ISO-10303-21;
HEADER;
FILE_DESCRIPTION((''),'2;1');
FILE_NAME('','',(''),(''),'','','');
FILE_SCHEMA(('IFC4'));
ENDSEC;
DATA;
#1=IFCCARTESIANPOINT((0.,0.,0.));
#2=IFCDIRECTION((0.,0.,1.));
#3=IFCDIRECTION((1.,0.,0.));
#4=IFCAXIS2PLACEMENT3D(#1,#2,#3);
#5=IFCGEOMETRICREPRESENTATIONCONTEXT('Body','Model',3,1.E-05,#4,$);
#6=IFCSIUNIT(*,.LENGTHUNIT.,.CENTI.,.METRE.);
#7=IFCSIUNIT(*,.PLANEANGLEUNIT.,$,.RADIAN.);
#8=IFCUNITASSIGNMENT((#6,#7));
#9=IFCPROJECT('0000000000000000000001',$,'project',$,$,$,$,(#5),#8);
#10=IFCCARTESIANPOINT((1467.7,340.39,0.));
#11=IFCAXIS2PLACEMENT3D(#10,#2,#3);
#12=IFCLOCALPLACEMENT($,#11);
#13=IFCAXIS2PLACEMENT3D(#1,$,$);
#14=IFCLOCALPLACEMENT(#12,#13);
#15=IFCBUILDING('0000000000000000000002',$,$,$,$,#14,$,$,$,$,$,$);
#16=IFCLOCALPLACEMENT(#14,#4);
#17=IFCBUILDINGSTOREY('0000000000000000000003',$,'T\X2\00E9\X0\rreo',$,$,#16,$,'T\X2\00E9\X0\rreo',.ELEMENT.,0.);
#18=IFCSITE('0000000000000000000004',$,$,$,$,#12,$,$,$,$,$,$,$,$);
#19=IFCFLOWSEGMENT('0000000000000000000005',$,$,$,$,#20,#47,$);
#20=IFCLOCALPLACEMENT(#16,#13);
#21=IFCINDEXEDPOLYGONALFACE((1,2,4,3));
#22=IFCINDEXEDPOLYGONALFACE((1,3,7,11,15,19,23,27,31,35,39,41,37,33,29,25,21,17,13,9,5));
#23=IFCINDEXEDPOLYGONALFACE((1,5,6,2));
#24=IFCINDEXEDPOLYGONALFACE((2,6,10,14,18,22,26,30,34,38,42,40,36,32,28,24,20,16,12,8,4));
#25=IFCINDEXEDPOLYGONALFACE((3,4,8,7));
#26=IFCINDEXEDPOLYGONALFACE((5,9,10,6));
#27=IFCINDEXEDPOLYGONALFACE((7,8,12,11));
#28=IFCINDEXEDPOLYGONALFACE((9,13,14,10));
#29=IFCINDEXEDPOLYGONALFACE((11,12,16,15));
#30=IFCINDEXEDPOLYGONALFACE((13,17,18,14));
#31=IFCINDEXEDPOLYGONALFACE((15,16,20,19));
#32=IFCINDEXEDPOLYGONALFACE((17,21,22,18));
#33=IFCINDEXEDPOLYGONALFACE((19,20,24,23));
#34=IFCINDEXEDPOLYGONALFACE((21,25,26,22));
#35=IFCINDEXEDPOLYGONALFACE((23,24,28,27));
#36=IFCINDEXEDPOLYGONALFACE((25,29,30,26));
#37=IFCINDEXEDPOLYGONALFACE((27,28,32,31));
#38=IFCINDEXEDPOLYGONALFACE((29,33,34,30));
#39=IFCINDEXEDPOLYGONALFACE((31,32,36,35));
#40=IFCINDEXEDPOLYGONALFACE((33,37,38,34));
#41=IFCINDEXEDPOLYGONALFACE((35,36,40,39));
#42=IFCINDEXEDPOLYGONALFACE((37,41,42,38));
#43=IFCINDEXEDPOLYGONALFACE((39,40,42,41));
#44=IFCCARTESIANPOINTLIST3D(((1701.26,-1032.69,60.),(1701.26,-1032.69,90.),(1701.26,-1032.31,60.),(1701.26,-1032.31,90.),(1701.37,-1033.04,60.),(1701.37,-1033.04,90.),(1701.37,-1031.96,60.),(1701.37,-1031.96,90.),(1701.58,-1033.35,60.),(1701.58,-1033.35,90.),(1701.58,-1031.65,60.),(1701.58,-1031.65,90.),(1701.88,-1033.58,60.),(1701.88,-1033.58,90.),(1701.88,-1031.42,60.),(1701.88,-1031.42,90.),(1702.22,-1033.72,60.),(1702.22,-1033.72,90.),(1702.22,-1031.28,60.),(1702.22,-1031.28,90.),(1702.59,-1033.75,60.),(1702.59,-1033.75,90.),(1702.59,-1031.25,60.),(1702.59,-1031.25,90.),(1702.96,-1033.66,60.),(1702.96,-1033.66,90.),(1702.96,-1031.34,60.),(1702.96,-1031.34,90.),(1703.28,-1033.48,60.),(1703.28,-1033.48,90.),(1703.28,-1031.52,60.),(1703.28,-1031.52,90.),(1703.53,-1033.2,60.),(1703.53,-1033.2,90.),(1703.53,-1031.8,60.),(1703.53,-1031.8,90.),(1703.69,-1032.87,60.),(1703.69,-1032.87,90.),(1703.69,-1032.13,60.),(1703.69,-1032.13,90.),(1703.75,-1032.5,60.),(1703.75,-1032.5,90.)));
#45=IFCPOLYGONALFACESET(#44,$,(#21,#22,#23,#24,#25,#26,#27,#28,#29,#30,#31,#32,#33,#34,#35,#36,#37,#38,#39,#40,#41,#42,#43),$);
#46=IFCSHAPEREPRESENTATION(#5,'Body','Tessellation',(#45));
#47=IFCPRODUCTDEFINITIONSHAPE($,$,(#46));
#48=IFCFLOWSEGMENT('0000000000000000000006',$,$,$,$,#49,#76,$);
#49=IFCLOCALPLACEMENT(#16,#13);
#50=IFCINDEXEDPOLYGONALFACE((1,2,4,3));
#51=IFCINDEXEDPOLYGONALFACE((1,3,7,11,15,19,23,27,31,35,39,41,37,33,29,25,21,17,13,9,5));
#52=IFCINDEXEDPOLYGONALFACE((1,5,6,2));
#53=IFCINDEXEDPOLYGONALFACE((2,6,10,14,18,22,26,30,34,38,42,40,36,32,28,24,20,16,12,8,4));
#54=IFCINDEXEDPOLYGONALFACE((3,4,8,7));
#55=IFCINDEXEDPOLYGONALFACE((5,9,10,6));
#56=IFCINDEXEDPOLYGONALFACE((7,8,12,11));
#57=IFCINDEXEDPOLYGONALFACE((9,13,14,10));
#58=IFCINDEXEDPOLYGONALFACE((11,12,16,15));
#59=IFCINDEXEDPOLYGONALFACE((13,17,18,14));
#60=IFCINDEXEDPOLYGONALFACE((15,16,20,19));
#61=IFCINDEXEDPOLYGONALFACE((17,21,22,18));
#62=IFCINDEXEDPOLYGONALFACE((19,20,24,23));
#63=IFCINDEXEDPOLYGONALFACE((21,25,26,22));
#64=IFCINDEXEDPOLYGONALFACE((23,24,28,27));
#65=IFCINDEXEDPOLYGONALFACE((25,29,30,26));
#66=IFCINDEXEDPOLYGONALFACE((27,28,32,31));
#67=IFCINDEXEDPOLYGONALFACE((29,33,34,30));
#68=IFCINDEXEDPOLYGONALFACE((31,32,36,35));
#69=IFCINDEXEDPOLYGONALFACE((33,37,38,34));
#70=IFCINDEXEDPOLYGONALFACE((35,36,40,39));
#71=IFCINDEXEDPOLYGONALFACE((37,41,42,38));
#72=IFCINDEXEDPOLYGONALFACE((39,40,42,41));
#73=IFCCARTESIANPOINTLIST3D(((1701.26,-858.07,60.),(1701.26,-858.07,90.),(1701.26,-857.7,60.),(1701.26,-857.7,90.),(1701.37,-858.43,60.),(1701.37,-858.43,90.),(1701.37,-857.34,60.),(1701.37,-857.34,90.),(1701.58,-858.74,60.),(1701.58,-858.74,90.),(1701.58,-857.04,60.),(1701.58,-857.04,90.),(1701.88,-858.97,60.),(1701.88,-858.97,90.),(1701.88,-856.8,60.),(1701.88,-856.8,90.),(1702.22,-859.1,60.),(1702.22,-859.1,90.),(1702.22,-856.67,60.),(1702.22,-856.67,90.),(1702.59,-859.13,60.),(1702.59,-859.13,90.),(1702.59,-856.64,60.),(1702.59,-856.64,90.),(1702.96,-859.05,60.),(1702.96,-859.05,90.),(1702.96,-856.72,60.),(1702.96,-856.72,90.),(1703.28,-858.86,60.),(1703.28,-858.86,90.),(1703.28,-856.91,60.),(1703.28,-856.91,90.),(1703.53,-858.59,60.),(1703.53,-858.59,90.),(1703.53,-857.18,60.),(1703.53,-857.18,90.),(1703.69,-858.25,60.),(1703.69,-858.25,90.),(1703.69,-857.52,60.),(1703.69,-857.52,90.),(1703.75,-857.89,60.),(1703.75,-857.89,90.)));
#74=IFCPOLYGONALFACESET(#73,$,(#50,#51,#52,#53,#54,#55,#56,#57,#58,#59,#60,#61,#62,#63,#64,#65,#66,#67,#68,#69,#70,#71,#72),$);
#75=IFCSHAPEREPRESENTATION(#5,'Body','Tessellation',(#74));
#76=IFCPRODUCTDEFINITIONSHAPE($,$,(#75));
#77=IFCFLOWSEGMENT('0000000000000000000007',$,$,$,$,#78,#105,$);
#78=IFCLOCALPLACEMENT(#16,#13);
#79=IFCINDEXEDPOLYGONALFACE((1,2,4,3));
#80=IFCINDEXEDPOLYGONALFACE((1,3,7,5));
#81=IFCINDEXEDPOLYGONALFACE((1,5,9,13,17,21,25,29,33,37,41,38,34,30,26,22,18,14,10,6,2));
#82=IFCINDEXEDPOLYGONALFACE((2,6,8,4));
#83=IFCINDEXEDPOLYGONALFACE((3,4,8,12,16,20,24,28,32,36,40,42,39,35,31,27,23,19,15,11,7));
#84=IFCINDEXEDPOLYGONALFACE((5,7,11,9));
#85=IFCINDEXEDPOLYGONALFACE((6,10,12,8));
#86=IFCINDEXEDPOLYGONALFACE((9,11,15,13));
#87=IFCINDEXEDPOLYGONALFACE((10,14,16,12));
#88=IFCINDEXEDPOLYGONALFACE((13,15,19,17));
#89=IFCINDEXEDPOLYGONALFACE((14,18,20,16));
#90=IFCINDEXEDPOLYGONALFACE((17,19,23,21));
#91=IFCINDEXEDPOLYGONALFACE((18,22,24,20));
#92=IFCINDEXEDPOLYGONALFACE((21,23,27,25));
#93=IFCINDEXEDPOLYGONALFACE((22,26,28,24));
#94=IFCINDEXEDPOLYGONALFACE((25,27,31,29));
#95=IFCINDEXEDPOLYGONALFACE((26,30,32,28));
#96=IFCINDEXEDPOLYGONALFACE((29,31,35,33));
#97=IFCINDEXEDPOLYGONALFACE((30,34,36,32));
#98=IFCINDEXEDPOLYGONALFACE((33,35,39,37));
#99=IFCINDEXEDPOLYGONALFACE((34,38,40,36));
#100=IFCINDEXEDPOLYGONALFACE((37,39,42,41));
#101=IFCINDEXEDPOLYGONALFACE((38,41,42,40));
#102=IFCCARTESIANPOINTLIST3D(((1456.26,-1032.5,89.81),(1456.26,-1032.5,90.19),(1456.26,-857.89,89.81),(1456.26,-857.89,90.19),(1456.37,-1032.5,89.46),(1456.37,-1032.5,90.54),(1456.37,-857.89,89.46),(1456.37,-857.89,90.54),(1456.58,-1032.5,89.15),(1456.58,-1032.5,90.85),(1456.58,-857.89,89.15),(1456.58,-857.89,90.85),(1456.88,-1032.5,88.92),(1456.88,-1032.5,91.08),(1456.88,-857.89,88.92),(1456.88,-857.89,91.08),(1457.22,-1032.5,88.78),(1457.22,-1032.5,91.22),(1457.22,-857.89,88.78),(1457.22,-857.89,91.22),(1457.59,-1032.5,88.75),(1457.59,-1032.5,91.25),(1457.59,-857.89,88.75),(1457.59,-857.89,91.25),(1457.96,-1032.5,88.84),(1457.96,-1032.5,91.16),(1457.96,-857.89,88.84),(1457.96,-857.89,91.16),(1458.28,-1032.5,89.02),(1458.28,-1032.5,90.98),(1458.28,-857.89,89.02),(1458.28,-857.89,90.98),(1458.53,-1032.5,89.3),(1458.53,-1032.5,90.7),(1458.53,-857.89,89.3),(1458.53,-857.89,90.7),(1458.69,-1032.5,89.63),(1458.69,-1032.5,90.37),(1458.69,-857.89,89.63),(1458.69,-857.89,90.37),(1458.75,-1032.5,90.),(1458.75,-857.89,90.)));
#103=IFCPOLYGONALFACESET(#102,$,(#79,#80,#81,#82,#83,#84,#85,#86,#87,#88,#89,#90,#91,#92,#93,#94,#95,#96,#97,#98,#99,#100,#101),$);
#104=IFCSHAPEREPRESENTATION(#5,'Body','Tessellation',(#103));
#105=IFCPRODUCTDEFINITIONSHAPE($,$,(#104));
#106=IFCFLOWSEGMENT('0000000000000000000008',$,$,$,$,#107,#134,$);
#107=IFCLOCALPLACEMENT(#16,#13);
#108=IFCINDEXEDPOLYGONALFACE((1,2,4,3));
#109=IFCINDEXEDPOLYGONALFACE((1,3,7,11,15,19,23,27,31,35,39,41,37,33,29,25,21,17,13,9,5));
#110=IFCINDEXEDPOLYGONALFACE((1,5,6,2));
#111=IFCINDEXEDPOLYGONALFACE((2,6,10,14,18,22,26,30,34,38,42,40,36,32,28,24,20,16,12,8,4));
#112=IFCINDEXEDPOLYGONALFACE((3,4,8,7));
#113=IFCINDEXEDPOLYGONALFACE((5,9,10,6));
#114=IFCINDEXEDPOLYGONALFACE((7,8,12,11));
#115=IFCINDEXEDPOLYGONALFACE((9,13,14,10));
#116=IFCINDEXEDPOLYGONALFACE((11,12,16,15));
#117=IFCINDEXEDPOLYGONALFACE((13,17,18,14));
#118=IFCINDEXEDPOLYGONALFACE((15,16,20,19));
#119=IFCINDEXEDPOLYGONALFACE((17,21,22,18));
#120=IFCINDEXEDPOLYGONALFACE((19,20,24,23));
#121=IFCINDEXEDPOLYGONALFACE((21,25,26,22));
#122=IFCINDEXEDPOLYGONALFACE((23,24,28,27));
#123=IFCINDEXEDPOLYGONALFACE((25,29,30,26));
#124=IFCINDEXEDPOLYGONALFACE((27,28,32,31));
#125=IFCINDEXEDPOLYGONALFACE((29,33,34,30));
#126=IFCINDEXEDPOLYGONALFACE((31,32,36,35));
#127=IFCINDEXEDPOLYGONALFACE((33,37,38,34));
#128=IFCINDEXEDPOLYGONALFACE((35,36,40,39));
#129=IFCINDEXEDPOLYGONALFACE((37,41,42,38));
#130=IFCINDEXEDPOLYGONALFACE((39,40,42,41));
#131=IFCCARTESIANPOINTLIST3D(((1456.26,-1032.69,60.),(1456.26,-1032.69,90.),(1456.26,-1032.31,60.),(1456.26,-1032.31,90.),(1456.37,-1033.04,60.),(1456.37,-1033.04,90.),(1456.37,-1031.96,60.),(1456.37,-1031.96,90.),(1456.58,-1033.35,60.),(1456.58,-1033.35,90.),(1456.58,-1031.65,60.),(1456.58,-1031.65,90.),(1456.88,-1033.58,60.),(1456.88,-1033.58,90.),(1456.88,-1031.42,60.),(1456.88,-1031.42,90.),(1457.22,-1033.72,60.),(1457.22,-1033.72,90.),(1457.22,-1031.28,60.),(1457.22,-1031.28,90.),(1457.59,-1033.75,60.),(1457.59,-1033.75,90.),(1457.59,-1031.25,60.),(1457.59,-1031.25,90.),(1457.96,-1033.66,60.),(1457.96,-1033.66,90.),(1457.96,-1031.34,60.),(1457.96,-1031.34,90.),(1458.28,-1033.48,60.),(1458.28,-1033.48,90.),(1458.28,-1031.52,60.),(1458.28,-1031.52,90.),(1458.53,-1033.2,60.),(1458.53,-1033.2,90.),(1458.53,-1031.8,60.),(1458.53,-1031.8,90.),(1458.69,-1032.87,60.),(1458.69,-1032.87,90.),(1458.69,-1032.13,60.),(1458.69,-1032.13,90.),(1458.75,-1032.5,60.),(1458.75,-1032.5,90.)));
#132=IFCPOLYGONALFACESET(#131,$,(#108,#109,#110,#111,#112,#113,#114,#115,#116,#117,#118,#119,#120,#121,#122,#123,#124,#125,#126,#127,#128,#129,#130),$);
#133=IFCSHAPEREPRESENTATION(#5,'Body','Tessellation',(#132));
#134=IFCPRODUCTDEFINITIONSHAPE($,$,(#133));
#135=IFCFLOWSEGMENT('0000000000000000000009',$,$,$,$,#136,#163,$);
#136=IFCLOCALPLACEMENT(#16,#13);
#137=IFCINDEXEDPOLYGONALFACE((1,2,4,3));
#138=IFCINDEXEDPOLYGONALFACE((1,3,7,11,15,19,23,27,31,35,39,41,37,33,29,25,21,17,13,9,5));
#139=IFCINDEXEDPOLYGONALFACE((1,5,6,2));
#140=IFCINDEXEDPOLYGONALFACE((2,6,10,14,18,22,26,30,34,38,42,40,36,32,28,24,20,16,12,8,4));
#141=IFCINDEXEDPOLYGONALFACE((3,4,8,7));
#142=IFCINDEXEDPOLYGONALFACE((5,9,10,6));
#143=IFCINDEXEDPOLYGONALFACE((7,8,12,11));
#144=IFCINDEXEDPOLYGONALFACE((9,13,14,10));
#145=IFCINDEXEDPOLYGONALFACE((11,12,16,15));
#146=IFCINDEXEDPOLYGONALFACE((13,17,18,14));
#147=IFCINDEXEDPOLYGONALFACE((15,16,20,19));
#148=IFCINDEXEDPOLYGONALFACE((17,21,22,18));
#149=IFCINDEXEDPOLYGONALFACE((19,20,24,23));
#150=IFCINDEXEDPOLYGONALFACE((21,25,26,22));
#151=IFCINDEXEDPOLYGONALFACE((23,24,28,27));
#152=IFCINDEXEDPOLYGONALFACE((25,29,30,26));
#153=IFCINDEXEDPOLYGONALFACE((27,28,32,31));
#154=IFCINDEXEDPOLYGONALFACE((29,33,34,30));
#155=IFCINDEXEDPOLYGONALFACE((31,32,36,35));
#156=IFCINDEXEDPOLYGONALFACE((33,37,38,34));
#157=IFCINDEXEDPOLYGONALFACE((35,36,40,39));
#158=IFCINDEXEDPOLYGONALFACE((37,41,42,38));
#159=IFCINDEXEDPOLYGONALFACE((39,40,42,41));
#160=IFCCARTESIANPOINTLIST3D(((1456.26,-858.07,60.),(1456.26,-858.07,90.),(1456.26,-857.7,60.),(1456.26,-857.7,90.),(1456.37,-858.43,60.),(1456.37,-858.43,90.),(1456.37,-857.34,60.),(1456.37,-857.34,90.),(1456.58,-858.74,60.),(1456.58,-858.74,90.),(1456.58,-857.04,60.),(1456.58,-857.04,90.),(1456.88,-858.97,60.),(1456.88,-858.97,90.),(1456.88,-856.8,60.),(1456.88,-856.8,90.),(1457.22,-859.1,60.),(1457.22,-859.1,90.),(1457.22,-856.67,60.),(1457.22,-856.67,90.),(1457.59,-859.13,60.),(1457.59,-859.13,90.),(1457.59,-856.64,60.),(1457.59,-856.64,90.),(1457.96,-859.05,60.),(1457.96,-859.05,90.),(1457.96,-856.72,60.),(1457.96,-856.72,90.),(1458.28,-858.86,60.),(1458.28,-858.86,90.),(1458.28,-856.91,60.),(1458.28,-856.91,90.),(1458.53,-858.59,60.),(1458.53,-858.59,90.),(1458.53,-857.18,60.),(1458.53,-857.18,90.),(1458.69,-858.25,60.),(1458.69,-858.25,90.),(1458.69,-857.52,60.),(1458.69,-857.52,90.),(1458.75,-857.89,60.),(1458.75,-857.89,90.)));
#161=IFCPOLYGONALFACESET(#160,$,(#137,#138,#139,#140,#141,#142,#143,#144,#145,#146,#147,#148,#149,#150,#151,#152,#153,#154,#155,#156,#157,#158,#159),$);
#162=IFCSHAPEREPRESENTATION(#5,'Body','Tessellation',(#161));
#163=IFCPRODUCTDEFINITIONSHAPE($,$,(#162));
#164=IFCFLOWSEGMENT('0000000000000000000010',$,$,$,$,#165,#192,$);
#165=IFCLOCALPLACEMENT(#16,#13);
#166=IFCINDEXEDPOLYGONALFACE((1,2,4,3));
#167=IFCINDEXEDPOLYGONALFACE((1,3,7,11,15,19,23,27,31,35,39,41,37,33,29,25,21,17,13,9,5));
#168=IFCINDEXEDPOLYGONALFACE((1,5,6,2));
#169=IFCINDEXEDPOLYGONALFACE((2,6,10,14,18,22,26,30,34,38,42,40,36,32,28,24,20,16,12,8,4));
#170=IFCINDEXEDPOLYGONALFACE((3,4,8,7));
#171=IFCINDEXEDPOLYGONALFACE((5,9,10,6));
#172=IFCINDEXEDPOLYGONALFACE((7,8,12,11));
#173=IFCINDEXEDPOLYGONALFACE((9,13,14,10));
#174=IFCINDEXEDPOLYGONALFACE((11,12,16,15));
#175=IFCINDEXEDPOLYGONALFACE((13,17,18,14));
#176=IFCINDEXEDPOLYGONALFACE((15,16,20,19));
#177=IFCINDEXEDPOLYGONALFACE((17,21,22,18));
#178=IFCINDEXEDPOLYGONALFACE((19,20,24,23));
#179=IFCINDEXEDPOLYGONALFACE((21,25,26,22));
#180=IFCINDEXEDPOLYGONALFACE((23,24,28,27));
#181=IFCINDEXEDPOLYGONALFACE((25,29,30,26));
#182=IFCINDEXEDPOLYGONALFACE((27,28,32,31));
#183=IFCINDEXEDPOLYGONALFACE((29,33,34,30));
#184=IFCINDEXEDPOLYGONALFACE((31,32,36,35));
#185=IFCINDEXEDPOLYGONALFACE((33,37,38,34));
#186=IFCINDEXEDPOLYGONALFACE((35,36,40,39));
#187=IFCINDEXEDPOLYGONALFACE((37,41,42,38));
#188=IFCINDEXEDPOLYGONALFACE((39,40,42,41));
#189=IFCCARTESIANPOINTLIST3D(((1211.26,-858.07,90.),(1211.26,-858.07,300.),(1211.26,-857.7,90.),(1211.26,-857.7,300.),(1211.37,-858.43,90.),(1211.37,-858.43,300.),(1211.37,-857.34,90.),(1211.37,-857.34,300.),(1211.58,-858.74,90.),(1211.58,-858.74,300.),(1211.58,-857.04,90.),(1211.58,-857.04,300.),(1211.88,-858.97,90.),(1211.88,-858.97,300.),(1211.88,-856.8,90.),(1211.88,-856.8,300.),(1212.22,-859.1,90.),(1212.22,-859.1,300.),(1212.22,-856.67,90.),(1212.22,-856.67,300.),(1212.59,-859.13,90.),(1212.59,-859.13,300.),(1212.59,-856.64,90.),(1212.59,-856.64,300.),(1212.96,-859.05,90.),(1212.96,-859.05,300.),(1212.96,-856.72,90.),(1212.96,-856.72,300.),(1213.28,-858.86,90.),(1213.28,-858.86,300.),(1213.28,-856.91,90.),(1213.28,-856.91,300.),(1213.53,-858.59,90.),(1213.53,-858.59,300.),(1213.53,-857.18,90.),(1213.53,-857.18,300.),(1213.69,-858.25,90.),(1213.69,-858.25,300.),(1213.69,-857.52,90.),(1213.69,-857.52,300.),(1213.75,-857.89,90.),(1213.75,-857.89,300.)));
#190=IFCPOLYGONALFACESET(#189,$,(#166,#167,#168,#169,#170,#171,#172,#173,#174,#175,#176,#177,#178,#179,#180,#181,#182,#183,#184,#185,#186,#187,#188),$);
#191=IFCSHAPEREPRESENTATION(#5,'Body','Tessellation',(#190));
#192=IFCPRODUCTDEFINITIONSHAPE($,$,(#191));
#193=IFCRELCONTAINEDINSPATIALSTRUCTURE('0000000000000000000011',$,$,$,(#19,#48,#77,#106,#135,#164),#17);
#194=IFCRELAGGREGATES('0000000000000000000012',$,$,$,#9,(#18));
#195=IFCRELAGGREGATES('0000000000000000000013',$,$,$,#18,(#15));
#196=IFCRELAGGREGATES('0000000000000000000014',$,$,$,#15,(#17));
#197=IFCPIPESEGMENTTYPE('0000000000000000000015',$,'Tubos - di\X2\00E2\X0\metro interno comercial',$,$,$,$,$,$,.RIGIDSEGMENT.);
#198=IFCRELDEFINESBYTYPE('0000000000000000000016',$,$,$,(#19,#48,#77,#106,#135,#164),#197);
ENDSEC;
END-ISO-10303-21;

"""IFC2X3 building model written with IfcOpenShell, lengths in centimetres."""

from ifc_helpers import new_model, si_unit, frame, origin, origin_with_axes, origin_2d_with_axis, place, context, project, spatial, circle, extrude, type_object, element, save


model = new_model("IFC2X3")

# Units and contexts
model_context = context("Model", 3, precision=1e-05, world=origin_with_axes(), identifier="Body")
ifc_project = project(units=[si_unit("LENGTHUNIT", "METRE", prefix="CENTI"), si_unit("PLANEANGLEUNIT", "RADIAN")], contexts=[model_context])

# Site, building, storey
site_placement = place(None, frame((1467.7, 340.39, 0.0), z_axis=(0.0, 0.0, 1.0), x_axis=(1.0, 0.0, 0.0)))
site = spatial("IfcSite", under=ifc_project, at=site_placement)
building_placement = place(site_placement, origin())
building = spatial("IfcBuilding", under=site, at=building_placement)
storey_placement = place(building_placement, origin_with_axes())
storey = spatial("IfcBuildingStorey", under=building, at=storey_placement, Name="Térreo", LongName="Térreo", CompositionType="ELEMENT", Elevation=0.0)

# Flow segments
pipe_segment_type = type_object("IfcPipeSegmentType", Name="Tubos - diâmetro interno comercial", PredefinedType="RIGIDSEGMENT")
for number, where, z_axis, x_axis in (
    (1, (1702.5, -1032.5, 90.0), (0.0, 0.0, 1.0), (1.0, 0.0, 0.0)),
    (2, (1702.5, -857.89, 90.0), (0.0, 0.0, 1.0), (1.0, 0.0, 0.0)),
):
    element("IfcFlowSegment", number, at=place(storey_placement, frame(where, z_axis=z_axis, x_axis=x_axis)), inside=storey, type_object=pipe_segment_type, context=model_context, shape_type="SolidModel", body=[
        extrude(circle(Radius=1.25, at=origin_2d_with_axis()), frame((0.0, 0.0, 0.0), z_axis=(0.0, 0.0, -1.0), x_axis=(1.0, 0.0, 0.0)), (0.0, 0.0, 1.0), 30.0),
    ])
flow_segment_1_placement = place(storey_placement, frame((1457.5, -945.19, 91.25), z_axis=(0.0, 0.0, 1.0), x_axis=(1.0, 0.0, 0.0)))
element("IfcFlowSegment", 3, at=flow_segment_1_placement, inside=storey, type_object=pipe_segment_type, context=model_context, shape_type="SolidModel", body=[
    extrude(circle(Radius=1.25, at=origin_2d_with_axis()), frame((0.0, 87.31, -1.25), z_axis=(0.0, -1.0, 0.0), x_axis=(1.0, 0.0, 0.0)), (0.0, 0.0, 1.0), 174.61),
])
for number, where, z_axis, x_axis in (
    (4, (1457.5, -1032.5, 90.0), (0.0, 0.0, 1.0), (1.0, 0.0, 0.0)),
    (5, (1457.5, -857.89, 90.0), (0.0, 0.0, 1.0), (1.0, 0.0, 0.0)),
):
    element("IfcFlowSegment", number, at=place(storey_placement, frame(where, z_axis=z_axis, x_axis=x_axis)), inside=storey, type_object=pipe_segment_type, context=model_context, shape_type="SolidModel", body=[
        extrude(circle(Radius=1.25, at=origin_2d_with_axis()), frame((0.0, 0.0, 0.0), z_axis=(0.0, 0.0, -1.0), x_axis=(1.0, 0.0, 0.0)), (0.0, 0.0, 1.0), 30.0),
    ])
flow_segment_2_placement = place(storey_placement, frame((1212.5, -857.89, 300.0), z_axis=(0.0, 0.0, 1.0), x_axis=(1.0, 0.0, 0.0)))
element("IfcFlowSegment", 6, at=flow_segment_2_placement, inside=storey, type_object=pipe_segment_type, context=model_context, shape_type="SolidModel", body=[
    extrude(circle(Radius=1.25, at=origin_2d_with_axis()), frame((0.0, 0.0, 0.0), z_axis=(0.0, 0.0, -1.0), x_axis=(1.0, 0.0, 0.0)), (0.0, 0.0, 1.0), 210.0),
])

save(model, "model.ifc")
